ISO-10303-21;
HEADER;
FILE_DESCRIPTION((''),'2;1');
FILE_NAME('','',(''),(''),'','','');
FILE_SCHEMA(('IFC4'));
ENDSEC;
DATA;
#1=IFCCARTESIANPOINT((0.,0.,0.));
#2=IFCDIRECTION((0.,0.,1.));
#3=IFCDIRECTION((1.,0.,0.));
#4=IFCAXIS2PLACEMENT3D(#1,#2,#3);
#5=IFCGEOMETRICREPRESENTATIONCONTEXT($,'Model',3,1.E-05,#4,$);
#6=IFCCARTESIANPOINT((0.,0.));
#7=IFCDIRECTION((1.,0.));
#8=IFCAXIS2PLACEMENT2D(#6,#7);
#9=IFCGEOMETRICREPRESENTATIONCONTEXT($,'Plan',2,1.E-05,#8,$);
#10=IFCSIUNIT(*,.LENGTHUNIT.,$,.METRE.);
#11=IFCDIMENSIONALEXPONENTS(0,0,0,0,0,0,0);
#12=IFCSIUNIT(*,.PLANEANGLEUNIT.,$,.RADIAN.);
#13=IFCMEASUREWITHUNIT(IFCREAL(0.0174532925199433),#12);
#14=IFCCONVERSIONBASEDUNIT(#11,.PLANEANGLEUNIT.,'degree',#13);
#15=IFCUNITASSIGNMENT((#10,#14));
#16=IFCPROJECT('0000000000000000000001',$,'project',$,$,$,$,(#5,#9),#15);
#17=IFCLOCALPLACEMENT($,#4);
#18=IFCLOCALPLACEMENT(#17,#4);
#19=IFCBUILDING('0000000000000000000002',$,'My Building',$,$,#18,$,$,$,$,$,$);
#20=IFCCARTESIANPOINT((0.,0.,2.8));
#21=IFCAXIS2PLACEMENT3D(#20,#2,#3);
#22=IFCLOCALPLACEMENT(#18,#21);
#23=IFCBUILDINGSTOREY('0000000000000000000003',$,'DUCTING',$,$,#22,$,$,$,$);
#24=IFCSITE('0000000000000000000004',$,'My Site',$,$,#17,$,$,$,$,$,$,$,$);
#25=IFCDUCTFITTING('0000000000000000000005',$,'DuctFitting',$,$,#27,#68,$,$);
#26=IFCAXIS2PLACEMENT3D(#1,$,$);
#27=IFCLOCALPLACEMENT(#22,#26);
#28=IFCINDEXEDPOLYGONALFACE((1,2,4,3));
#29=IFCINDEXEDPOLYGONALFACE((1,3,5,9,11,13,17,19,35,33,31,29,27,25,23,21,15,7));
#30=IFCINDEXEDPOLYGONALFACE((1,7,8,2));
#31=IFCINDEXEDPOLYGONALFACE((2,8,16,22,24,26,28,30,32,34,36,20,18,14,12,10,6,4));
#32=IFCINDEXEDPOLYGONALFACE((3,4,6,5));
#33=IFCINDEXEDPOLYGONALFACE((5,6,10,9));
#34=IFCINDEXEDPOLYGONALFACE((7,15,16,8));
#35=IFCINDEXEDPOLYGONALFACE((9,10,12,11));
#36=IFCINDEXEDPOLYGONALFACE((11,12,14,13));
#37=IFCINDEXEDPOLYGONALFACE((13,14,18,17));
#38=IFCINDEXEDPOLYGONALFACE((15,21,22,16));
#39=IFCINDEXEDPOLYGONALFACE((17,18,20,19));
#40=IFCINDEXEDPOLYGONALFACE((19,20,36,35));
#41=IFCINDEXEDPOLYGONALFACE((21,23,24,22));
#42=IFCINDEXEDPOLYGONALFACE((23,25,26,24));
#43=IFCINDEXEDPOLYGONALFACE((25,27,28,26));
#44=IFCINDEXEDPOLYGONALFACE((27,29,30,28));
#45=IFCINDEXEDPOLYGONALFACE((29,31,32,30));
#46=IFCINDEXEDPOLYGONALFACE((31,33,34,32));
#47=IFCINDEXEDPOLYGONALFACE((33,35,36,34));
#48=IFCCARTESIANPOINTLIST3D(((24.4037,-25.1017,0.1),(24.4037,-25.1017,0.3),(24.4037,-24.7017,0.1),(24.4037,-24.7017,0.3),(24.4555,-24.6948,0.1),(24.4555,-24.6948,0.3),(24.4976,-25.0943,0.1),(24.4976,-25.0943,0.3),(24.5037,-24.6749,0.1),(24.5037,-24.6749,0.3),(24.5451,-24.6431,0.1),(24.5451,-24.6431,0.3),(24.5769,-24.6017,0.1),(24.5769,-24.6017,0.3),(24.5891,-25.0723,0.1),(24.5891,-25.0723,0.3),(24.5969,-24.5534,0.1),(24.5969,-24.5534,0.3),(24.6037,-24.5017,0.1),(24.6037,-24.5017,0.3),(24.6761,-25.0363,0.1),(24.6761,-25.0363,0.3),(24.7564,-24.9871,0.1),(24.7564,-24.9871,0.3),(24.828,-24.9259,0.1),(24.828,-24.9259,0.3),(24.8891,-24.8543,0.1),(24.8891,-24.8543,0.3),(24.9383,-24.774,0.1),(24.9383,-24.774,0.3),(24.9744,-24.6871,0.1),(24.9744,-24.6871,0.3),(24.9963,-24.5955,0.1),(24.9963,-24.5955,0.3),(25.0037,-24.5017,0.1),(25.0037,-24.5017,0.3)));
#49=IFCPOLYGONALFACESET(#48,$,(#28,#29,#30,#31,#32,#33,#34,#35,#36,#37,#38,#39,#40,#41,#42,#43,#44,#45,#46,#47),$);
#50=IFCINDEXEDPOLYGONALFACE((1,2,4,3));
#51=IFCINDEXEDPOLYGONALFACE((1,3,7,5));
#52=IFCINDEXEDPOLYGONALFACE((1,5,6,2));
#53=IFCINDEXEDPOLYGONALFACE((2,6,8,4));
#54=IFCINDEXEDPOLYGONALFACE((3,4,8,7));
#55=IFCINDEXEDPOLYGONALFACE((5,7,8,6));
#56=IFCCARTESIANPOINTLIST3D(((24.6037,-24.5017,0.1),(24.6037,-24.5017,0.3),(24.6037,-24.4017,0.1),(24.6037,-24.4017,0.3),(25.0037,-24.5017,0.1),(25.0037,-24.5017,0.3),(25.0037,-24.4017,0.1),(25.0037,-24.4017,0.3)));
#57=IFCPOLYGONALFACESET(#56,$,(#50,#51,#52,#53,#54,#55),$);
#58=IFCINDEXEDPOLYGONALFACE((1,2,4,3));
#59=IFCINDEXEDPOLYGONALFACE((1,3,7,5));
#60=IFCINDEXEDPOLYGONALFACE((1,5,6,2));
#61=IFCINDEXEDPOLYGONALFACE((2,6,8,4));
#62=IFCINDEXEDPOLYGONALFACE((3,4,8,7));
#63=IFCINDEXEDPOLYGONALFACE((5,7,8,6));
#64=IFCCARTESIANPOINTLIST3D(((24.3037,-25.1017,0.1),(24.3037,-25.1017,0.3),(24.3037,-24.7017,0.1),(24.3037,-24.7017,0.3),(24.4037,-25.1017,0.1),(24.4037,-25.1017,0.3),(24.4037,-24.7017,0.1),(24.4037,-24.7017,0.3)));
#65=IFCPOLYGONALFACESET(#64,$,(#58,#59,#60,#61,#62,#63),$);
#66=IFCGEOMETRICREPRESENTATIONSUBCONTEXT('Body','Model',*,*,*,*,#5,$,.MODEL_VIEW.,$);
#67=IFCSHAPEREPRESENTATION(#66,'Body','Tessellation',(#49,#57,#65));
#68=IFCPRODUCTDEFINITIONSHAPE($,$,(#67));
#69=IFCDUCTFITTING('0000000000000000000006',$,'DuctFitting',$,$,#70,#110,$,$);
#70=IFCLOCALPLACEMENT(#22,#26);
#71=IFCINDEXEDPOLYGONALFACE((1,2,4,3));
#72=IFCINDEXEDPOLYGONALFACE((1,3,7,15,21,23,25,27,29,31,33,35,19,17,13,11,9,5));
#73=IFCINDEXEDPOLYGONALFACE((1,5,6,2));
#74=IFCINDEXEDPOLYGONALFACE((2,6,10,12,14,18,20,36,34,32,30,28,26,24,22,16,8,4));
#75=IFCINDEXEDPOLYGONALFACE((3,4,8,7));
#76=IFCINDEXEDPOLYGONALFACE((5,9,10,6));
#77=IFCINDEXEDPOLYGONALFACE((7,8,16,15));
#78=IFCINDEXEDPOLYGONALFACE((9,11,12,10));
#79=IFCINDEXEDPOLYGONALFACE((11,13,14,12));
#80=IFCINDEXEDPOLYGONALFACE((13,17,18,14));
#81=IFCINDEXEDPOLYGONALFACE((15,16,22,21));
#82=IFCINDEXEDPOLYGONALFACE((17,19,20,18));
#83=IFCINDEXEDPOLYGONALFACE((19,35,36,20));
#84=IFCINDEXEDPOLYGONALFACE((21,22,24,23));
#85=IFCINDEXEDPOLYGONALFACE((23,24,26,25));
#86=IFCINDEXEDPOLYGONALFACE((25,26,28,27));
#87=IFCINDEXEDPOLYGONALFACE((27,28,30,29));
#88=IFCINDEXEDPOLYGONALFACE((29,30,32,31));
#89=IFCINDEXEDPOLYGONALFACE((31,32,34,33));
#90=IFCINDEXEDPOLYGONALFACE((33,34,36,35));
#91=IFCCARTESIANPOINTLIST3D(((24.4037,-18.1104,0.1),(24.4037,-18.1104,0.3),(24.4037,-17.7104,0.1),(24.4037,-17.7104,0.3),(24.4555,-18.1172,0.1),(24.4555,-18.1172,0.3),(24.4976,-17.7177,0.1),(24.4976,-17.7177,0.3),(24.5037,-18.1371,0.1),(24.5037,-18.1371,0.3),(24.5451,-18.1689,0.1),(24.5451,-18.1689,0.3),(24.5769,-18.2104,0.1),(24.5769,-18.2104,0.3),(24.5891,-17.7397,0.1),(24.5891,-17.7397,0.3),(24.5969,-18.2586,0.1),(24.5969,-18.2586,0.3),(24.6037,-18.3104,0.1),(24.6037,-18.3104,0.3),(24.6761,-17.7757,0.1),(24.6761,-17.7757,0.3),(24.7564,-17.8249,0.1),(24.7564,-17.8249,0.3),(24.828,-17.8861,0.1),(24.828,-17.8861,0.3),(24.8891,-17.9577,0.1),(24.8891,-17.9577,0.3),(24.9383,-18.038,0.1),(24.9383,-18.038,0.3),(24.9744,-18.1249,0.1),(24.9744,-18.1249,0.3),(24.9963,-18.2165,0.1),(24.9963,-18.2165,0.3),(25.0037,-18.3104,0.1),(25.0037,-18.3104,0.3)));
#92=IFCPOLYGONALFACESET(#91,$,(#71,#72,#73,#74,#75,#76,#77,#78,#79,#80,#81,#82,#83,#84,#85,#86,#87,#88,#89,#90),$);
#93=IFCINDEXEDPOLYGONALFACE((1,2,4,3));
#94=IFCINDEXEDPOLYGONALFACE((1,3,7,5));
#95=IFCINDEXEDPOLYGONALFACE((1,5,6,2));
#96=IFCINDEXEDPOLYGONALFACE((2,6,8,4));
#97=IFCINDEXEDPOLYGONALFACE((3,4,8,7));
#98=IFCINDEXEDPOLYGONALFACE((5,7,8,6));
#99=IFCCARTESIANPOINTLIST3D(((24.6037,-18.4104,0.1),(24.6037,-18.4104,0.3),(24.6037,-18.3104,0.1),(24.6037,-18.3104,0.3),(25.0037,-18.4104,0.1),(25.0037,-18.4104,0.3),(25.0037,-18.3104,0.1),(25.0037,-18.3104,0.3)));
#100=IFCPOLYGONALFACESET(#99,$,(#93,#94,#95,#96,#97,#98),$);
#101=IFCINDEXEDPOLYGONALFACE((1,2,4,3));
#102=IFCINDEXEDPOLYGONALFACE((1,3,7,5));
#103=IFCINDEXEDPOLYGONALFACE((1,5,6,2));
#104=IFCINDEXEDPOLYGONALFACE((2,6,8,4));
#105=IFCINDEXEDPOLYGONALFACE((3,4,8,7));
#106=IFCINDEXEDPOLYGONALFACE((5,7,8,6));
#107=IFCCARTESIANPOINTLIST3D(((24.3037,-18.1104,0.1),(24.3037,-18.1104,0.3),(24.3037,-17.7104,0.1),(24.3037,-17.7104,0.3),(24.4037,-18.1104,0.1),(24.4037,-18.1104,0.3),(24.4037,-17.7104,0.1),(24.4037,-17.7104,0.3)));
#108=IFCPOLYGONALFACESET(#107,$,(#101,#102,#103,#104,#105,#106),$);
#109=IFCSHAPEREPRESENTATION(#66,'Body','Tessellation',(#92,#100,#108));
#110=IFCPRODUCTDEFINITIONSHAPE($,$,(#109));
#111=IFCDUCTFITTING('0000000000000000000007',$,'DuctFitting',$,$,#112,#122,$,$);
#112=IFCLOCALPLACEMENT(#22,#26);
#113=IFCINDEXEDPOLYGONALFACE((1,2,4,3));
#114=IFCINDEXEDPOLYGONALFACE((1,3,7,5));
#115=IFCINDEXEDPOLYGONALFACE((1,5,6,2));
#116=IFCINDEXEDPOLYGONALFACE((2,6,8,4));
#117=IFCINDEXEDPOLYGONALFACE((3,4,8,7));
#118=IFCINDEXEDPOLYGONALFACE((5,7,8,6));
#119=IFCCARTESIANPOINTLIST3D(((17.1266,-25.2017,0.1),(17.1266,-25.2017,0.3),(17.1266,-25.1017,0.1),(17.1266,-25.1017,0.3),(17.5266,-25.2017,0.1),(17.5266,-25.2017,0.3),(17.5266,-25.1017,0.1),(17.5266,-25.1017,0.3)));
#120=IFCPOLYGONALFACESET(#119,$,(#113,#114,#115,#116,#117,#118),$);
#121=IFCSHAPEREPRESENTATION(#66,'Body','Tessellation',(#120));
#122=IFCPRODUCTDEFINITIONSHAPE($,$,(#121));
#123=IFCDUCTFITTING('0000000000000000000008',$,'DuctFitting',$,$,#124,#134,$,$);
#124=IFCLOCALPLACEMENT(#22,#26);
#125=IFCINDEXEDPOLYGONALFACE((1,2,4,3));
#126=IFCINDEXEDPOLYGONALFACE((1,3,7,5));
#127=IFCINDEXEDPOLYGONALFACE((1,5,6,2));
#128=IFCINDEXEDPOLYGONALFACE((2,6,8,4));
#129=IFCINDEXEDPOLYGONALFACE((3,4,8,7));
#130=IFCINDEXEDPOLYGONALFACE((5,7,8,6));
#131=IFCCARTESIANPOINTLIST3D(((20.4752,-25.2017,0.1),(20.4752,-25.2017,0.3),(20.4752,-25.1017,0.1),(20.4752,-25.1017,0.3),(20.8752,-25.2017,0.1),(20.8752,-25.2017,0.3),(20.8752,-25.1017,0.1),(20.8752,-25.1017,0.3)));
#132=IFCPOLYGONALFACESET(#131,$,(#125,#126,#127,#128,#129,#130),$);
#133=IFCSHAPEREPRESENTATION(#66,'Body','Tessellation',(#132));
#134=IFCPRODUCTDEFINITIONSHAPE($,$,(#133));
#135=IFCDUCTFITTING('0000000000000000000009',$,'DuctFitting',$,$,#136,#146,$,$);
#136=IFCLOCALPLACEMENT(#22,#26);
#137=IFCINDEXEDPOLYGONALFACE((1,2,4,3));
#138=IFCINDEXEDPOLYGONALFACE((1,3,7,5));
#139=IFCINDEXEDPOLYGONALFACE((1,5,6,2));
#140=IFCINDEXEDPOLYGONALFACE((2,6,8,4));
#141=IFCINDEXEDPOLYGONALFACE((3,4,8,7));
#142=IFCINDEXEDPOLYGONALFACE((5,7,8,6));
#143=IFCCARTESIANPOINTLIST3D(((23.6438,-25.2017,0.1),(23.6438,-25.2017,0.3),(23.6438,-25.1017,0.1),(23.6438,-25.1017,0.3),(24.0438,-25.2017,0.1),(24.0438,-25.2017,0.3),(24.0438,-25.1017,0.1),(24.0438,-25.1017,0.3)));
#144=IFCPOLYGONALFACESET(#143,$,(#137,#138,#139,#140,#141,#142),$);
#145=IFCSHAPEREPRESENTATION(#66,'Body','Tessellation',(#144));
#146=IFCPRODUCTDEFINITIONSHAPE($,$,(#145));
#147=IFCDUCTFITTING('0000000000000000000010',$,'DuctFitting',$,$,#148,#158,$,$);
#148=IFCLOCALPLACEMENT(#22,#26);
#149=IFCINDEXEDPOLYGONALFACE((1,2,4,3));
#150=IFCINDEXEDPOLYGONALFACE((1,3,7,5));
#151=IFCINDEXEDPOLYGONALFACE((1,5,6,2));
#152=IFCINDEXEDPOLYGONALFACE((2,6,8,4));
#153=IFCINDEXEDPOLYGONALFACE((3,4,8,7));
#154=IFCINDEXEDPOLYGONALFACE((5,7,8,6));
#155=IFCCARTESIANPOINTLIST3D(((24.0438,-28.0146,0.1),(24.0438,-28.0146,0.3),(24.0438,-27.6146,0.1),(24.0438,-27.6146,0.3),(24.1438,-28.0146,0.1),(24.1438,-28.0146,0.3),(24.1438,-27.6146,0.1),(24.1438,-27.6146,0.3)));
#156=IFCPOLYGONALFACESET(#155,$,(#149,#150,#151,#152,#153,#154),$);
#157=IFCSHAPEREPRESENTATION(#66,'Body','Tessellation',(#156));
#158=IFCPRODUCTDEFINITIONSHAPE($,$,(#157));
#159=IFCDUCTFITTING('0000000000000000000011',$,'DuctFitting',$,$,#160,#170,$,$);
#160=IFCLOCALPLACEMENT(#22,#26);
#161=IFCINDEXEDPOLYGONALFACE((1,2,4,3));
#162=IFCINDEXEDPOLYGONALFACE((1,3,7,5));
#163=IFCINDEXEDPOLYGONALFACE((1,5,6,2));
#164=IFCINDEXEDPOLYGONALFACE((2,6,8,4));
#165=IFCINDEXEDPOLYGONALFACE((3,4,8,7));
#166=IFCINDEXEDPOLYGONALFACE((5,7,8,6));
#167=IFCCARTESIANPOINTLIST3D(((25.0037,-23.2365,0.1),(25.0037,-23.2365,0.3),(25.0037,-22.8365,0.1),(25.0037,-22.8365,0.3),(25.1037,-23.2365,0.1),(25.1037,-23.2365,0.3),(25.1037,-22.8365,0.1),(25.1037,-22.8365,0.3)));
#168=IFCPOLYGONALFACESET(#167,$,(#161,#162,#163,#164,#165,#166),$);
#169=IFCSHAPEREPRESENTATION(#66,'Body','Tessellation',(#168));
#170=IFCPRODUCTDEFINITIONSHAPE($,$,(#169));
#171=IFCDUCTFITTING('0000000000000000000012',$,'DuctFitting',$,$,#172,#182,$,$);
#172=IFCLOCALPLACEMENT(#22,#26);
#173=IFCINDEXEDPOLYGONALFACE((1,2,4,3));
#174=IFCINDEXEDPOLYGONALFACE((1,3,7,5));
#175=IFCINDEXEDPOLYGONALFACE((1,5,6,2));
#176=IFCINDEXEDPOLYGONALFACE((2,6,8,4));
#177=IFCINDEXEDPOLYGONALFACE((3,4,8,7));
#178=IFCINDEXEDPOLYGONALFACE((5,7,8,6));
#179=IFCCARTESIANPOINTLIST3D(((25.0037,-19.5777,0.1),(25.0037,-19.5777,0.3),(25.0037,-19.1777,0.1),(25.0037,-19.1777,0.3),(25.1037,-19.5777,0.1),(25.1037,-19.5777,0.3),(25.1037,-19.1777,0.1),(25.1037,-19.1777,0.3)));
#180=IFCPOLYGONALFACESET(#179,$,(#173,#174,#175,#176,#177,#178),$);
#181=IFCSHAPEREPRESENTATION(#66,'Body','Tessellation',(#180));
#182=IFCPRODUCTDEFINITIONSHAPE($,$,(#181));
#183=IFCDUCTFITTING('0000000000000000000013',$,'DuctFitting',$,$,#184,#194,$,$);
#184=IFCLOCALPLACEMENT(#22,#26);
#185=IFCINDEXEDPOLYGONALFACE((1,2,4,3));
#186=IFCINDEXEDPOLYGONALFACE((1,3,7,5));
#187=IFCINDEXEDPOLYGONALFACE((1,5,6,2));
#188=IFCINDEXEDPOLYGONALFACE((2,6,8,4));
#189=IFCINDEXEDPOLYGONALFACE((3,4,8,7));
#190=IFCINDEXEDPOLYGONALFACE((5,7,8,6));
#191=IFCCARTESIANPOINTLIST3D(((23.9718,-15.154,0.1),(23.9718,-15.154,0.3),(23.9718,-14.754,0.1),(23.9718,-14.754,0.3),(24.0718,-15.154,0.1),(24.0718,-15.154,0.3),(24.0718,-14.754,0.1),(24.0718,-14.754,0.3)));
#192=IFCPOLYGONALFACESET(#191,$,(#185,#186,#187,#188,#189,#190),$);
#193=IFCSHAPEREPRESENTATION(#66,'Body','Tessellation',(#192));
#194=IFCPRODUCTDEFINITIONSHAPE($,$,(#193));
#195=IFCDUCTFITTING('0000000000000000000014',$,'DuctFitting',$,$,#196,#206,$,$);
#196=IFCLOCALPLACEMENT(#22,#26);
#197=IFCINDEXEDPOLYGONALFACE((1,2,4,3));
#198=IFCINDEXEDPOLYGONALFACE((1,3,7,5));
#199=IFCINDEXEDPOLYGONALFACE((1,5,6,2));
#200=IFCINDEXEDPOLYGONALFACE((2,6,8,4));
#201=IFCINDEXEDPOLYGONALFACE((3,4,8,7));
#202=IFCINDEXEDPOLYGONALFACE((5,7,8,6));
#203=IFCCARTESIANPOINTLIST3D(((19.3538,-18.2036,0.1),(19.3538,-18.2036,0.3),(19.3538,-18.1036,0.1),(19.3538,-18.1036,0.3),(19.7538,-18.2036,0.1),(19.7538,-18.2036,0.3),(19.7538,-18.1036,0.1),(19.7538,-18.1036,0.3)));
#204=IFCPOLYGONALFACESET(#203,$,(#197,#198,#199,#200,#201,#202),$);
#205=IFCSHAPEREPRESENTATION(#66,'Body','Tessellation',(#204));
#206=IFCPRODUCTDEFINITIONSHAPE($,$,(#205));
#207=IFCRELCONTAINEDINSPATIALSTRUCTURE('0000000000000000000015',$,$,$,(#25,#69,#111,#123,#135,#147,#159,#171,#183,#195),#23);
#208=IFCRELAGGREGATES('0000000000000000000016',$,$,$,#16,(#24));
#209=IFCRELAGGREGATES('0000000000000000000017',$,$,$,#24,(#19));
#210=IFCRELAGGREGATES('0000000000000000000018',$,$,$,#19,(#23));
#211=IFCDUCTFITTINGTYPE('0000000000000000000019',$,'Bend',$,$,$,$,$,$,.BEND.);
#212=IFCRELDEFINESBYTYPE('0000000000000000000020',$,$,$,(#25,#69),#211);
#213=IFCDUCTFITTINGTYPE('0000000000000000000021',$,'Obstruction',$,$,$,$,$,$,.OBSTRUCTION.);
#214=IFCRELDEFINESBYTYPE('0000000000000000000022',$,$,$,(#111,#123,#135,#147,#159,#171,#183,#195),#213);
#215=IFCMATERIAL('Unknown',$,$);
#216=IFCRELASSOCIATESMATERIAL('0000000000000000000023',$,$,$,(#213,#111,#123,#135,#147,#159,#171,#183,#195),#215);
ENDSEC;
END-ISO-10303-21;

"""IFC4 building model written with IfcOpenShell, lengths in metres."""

from ifc_helpers import new_model, entity, si_unit, converted_unit, frame, origin_with_axes, origin_2d_with_axis, place, context, subcontext, project, spatial, line, arc, indexed_curve, rectangle, outline, extrude, source, transform, mapped, material, material_profile, profile_set, profile_usage, type_object, type_shapes, element, save


model = new_model("IFC4")

# Units and contexts
model_context = context("Model", 3, precision=1e-05, world=origin_with_axes())
plan_context = context("Plan", 2, precision=1e-05, world=origin_2d_with_axis())
body_context = subcontext(model_context, "Body", "Model", "MODEL_VIEW")
ifc_project = project(units=[si_unit("LENGTHUNIT", "METRE"), converted_unit("PLANEANGLEUNIT", "degree", entity("IfcReal", 0.0174532925199433), si_unit("PLANEANGLEUNIT", "RADIAN"), dimensions=[0, 0, 0, 0, 0, 0, 0])], contexts=[model_context, plan_context])

# Site, building, storey
site_placement = place(None, origin_with_axes())
site = spatial("IfcSite", under=ifc_project, at=site_placement, Name="My Site")
building_placement = place(site_placement, origin_with_axes())
building = spatial("IfcBuilding", under=site, at=building_placement, Name="My Building")
storey_placement = place(building_placement, frame((0.0, 0.0, 2.8), z_axis=(0.0, 0.0, 1.0), x_axis=(1.0, 0.0, 0.0)))
storey = spatial("IfcBuildingStorey", under=building, at=storey_placement, Name="DUCTING")

# Shared definitions
ifc_material = material(Name="Unknown")

# Duct fittings
duct_fitting_type_1 = type_object("IfcDuctFittingType", Name="Bend", PredefinedType="BEND")
shared_shape = source(origin_with_axes(), body_context, "Body", "SweptSolid", [
    extrude(outline(indexed_curve([(0.2, 0.0), (0.2586, 0.1414), (0.4, 0.2), (0.4, 0.6), (-0.0243, 0.4243), (-0.2, 0.0)], segments=[arc(1, 2, 3), line(3, 4), arc(4, 5, 6), line(6, 1)])), frame((0.0, -0.1, 0.1), z_axis=(0.0, -1.0, 0.0), x_axis=(1.0, 0.0, 0.0)), (0.0, 0.0, -1.0), 0.2),
    extrude(rectangle(XDim=0.4, YDim=0.2), origin_with_axes(), (0.0, 0.0, 1.0), 0.1),
    extrude(rectangle(XDim=0.4, YDim=0.2), frame((0.4, 0.0, 0.5), z_axis=(1.0, 0.0, 0.0), x_axis=(0.0, 0.0, 1.0)), (0.0, 0.0, 1.0), 0.1),
])
type_shapes(duct_fitting_type_1, [shared_shape])
for number, where, z_axis, x_axis, name in (
    (1, (24.8037, -24.4017, 0.2), (0.0, -1.0, 0.0), (-1.0, 0.0, 0.0), "DuctFitting"),
    (2, (24.8037, -18.4104, 0.2), (0.0, 1.0, 0.0), (-1.0, 0.0, 0.0), "DuctFitting"),
):
    element("IfcDuctFitting", number, at=place(storey_placement, frame(where, z_axis=z_axis, x_axis=x_axis)), inside=storey, type_object=duct_fitting_type_1, Name=name, context=body_context, shape_type="MappedRepresentation", body=[
        mapped(shared_shape, transform((0.0, 0.0, 0.0), x_axis=(1.0, 0.0, 0.0), y_axis=(0.0, 1.0, 0.0), z_axis=(0.0, 0.0, 1.0), scale=1.0)),
    ])
ifc_material_profile_1 = material_profile(ifc_material, rectangle(XDim=0.4, YDim=0.2))
ifc_profile_set_1 = profile_set([ifc_material_profile_1])
ifc_profile_usage_1 = profile_usage(ifc_profile_set_1, cardinal=5)
duct_fitting_type_2 = type_object("IfcDuctFittingType", Name="Obstruction", PredefinedType="OBSTRUCTION", material=ifc_profile_set_1)
duct_fitting_1_placement = place(storey_placement, frame((17.3266, -25.1017, 0.2), z_axis=(0.0, -1.0, 0.0), x_axis=(1.0, 0.0, 0.0)))
element("IfcDuctFitting", 3, at=duct_fitting_1_placement, inside=storey, type_object=duct_fitting_type_2, material=ifc_profile_usage_1, Name="DuctFitting", context=body_context, shape_type="SweptSolid", body=[
    extrude(rectangle(XDim=0.4, YDim=0.2), origin_with_axes(), (0.0, 0.0, 1.0), 0.1),
])
ifc_profile_usage_2 = profile_usage(ifc_profile_set_1, cardinal=5)
duct_fitting_2_placement = place(storey_placement, frame((20.6752, -25.1017, 0.2), z_axis=(0.0, -1.0, 0.0), x_axis=(1.0, 0.0, 0.0)))
element("IfcDuctFitting", 4, at=duct_fitting_2_placement, inside=storey, type_object=duct_fitting_type_2, material=ifc_profile_usage_2, Name="DuctFitting", context=body_context, shape_type="SweptSolid", body=[
    extrude(rectangle(XDim=0.4, YDim=0.2), origin_with_axes(), (0.0, 0.0, 1.0), 0.1),
])
ifc_profile_usage_3 = profile_usage(ifc_profile_set_1, cardinal=5)
duct_fitting_3_placement = place(storey_placement, frame((23.8438, -25.1017, 0.2), z_axis=(0.0, -1.0, 0.0), x_axis=(1.0, 0.0, 0.0)))
element("IfcDuctFitting", 5, at=duct_fitting_3_placement, inside=storey, type_object=duct_fitting_type_2, material=ifc_profile_usage_3, Name="DuctFitting", context=body_context, shape_type="SweptSolid", body=[
    extrude(rectangle(XDim=0.4, YDim=0.2), origin_with_axes(), (0.0, 0.0, 1.0), 0.1),
])
ifc_profile_usage_4 = profile_usage(ifc_profile_set_1, cardinal=5)
duct_fitting_4_placement = place(storey_placement, frame((24.0438, -27.8146, 0.2), z_axis=(1.0, 0.0, 0.0), x_axis=(0.0, 1.0, 0.0)))
element("IfcDuctFitting", 6, at=duct_fitting_4_placement, inside=storey, type_object=duct_fitting_type_2, material=ifc_profile_usage_4, Name="DuctFitting", context=body_context, shape_type="SweptSolid", body=[
    extrude(rectangle(XDim=0.4, YDim=0.2), origin_with_axes(), (0.0, 0.0, 1.0), 0.1),
])
ifc_profile_usage_5 = profile_usage(ifc_profile_set_1, cardinal=5)
duct_fitting_5_placement = place(storey_placement, frame((25.0037, -23.0365, 0.2), z_axis=(1.0, 0.0, 0.0), x_axis=(0.0, 1.0, 0.0)))
element("IfcDuctFitting", 7, at=duct_fitting_5_placement, inside=storey, type_object=duct_fitting_type_2, material=ifc_profile_usage_5, Name="DuctFitting", context=body_context, shape_type="SweptSolid", body=[
    extrude(rectangle(XDim=0.4, YDim=0.2), origin_with_axes(), (0.0, 0.0, 1.0), 0.1),
])
ifc_profile_usage_6 = profile_usage(ifc_profile_set_1, cardinal=5)
duct_fitting_6_placement = place(storey_placement, frame((25.0037, -19.3777, 0.2), z_axis=(1.0, 0.0, 0.0), x_axis=(0.0, 1.0, 0.0)))
element("IfcDuctFitting", 8, at=duct_fitting_6_placement, inside=storey, type_object=duct_fitting_type_2, material=ifc_profile_usage_6, Name="DuctFitting", context=body_context, shape_type="SweptSolid", body=[
    extrude(rectangle(XDim=0.4, YDim=0.2), origin_with_axes(), (0.0, 0.0, 1.0), 0.1),
])
ifc_profile_usage_7 = profile_usage(ifc_profile_set_1, cardinal=5)
duct_fitting_7_placement = place(storey_placement, frame((23.9718, -14.954, 0.2), z_axis=(1.0, 0.0, 0.0), x_axis=(0.0, 1.0, 0.0)))
element("IfcDuctFitting", 9, at=duct_fitting_7_placement, inside=storey, type_object=duct_fitting_type_2, material=ifc_profile_usage_7, Name="DuctFitting", context=body_context, shape_type="SweptSolid", body=[
    extrude(rectangle(XDim=0.4, YDim=0.2), origin_with_axes(), (0.0, 0.0, 1.0), 0.1),
])
ifc_profile_usage_8 = profile_usage(ifc_profile_set_1, cardinal=5)
duct_fitting_8_placement = place(storey_placement, frame((19.5538, -18.1036, 0.2), z_axis=(0.0, -1.0, 0.0), x_axis=(1.0, 0.0, 0.0)))
element("IfcDuctFitting", 10, at=duct_fitting_8_placement, inside=storey, type_object=duct_fitting_type_2, material=ifc_profile_usage_8, Name="DuctFitting", context=body_context, shape_type="SweptSolid", body=[
    extrude(rectangle(XDim=0.4, YDim=0.2), origin_with_axes(), (0.0, 0.0, 1.0), 0.1),
])

save(model, "model.ifc")
